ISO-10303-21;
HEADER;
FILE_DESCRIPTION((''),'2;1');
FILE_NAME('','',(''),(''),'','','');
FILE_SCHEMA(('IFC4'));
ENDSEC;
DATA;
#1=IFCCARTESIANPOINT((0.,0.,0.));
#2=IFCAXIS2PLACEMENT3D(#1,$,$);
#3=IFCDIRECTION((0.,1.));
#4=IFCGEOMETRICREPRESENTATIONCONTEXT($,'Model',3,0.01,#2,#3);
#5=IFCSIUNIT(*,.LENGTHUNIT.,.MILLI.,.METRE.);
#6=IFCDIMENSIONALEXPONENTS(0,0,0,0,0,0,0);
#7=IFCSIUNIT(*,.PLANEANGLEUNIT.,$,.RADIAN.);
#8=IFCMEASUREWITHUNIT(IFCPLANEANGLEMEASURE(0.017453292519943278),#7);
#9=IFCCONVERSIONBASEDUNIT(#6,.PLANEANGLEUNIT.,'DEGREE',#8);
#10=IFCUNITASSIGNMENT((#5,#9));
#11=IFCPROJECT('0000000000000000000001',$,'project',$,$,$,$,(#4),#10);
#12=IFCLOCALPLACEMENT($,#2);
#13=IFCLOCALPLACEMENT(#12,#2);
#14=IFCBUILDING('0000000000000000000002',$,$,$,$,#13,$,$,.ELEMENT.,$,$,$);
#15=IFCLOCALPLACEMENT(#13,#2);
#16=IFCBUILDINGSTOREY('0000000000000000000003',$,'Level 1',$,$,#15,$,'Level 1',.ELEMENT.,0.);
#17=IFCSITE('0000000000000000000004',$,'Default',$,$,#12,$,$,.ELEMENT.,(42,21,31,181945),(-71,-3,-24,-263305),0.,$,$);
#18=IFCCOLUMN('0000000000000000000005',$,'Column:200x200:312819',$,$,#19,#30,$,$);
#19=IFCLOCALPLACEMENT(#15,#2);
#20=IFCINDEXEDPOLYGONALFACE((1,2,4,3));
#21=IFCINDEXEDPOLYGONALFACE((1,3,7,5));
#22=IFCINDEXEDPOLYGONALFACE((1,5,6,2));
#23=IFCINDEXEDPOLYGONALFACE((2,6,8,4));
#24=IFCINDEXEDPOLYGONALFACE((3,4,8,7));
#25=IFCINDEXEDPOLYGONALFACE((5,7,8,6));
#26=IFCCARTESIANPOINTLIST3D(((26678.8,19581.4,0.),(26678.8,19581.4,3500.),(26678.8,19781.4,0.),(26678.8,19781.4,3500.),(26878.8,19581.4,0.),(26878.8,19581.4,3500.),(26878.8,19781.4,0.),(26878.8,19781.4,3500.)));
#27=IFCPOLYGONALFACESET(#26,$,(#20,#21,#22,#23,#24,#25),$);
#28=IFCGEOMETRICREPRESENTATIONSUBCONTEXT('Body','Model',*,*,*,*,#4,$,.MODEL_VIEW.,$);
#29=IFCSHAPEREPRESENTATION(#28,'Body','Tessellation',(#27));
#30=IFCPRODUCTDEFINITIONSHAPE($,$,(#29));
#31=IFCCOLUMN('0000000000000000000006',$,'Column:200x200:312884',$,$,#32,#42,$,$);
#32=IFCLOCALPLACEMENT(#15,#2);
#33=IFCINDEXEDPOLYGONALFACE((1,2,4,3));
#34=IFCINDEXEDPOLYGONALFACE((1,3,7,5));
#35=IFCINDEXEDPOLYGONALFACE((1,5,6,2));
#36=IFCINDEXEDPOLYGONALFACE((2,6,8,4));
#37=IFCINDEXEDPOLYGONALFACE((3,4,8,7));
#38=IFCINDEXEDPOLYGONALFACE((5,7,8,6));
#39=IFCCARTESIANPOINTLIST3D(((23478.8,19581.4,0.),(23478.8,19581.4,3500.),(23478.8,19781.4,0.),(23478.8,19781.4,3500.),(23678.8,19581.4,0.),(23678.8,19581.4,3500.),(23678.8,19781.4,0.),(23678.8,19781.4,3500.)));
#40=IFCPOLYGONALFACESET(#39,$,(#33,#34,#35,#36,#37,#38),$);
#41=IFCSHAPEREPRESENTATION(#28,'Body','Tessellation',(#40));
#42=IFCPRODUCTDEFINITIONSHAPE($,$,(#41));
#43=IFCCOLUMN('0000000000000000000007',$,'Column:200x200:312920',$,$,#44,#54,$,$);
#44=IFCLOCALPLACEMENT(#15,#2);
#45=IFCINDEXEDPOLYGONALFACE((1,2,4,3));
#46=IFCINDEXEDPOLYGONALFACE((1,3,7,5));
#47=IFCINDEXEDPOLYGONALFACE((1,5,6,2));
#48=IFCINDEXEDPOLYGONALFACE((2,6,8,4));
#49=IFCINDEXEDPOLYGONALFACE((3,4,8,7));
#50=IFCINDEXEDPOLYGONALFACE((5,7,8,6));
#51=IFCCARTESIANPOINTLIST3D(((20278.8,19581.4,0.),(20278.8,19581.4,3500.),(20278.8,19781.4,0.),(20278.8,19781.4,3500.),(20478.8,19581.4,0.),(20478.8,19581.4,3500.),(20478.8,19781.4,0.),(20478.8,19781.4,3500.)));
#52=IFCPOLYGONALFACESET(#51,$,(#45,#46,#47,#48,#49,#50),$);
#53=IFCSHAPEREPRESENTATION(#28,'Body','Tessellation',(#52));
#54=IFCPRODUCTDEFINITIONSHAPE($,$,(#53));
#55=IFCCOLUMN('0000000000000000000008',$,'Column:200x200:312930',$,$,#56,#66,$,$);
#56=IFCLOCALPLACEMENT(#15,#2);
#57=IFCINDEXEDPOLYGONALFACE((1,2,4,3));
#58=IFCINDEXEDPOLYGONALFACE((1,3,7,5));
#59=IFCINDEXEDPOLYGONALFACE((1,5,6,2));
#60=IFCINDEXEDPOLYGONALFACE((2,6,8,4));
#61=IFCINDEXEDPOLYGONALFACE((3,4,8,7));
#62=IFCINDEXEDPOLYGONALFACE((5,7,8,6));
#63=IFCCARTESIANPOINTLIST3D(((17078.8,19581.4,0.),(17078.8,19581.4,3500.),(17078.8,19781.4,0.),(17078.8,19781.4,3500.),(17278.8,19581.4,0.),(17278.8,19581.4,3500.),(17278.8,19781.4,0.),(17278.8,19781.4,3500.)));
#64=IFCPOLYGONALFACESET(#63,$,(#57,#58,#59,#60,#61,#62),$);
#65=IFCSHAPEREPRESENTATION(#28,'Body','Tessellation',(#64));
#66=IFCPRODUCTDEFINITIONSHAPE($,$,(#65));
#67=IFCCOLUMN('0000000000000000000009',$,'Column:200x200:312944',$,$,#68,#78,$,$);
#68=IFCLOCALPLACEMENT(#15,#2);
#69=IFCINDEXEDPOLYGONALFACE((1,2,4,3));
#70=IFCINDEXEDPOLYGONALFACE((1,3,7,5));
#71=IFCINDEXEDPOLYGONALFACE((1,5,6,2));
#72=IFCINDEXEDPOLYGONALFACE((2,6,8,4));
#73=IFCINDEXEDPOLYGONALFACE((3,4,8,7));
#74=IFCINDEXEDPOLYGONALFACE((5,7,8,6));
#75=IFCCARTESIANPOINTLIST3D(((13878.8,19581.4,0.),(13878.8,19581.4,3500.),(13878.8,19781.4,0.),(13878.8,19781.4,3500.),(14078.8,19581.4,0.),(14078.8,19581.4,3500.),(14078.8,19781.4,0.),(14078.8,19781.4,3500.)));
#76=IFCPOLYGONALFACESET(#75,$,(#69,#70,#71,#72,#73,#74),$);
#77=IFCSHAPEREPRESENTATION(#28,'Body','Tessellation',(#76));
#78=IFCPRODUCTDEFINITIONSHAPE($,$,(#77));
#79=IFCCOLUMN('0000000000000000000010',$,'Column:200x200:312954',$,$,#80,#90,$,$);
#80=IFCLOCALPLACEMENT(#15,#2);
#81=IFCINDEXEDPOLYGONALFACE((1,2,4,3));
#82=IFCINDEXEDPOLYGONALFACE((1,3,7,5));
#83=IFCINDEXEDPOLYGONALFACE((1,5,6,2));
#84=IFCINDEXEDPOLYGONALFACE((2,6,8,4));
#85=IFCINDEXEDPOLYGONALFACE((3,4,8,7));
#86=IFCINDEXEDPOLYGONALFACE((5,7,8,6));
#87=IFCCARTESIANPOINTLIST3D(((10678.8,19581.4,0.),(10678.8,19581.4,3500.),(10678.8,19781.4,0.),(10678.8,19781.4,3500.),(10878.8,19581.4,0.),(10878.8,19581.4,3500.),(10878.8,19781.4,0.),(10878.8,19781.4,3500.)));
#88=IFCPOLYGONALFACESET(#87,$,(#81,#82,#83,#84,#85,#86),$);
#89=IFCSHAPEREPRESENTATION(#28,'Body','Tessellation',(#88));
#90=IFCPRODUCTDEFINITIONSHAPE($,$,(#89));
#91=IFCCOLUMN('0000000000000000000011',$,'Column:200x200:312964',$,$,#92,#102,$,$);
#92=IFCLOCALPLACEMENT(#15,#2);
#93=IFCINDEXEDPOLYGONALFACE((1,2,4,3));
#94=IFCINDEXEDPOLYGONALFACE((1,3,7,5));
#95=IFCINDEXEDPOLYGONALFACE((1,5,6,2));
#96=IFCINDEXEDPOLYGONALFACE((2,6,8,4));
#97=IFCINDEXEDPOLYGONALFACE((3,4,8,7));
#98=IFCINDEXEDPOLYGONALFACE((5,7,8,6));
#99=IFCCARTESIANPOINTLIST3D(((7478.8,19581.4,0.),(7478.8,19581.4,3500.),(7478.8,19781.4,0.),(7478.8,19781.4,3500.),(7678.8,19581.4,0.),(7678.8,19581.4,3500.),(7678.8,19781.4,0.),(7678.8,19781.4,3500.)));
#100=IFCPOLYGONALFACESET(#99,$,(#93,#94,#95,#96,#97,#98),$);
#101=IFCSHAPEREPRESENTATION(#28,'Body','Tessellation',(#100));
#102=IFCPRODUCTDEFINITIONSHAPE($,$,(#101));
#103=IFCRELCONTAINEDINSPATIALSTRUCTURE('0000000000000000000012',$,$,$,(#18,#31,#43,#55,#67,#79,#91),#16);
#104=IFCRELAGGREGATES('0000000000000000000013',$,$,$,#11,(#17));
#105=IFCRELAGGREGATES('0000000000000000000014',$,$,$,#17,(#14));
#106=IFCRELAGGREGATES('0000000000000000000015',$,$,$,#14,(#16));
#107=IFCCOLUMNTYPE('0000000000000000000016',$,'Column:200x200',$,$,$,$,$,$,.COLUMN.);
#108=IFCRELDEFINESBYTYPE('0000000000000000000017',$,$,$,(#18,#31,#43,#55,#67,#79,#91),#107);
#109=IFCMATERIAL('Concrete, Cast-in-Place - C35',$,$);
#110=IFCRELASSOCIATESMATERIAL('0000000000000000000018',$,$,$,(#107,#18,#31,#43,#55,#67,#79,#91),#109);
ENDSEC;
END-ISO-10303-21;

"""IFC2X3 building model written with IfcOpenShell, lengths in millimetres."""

from ifc_helpers import new_model, entity, si_unit, converted_unit, direction, frame, frame_2d, origin, place, context, subcontext, project, spatial, rectangle, extrude, source, transform, mapped, material, type_object, type_shapes, element, save


model = new_model("IFC2X3")

# Units and contexts
model_context = context("Model", 3, precision=0.01, world=origin(), true_north=direction((0.0, 1.0)))
body_context = subcontext(model_context, "Body", "Model", "MODEL_VIEW")
ifc_project = project(units=[si_unit("LENGTHUNIT", "METRE", prefix="MILLI"), converted_unit("PLANEANGLEUNIT", "DEGREE", entity("IfcPlaneAngleMeasure", 0.017453292519943278), si_unit("PLANEANGLEUNIT", "RADIAN"), dimensions=[0, 0, 0, 0, 0, 0, 0])], contexts=[model_context])

# Site, building, storey
site_placement = place(None, origin())
site = spatial("IfcSite", under=ifc_project, at=site_placement, Name="Default", CompositionType="ELEMENT", RefLatitude=(42, 21, 31, 181945), RefLongitude=(-71, -3, -24, -263305), RefElevation=0.0)
building_placement = place(site_placement, origin())
building = spatial("IfcBuilding", under=site, at=building_placement, CompositionType="ELEMENT")
storey_placement = place(building_placement, origin())
storey = spatial("IfcBuildingStorey", under=building, at=storey_placement, Name="Level 1", LongName="Level 1", CompositionType="ELEMENT", Elevation=0.0)

# Columns
ifc_material = material(Name="Concrete, Cast-in-Place - C35")
column_type_1 = type_object("IfcColumnType", Name="Column:200x200", PredefinedType="COLUMN", material=ifc_material)
shared_shape_1 = source(origin(), body_context, "Body", "SweptSolid", [
    extrude(rectangle(XDim=200.0, YDim=200.0, at=frame_2d((0.0, 0.0), x_axis=(1.0, 0.0))), frame((0.0, 0.0, 0.0), z_axis=(0.0, 0.0, 1.0), x_axis=(-1.0, 0.0, 0.0)), (0.0, 0.0, 1.0), 3500.0),
])
type_shapes(column_type_1, [shared_shape_1])
for number, where, name in (
    (1, (26778.8, 19681.4, 0.0), "Column:200x200:312819"),
    (2, (23578.8, 19681.4, 0.0), "Column:200x200:312884"),
    (3, (20378.8, 19681.4, 0.0), "Column:200x200:312920"),
    (4, (17178.8, 19681.4, 0.0), "Column:200x200:312930"),
    (5, (13978.8, 19681.4, 0.0), "Column:200x200:312944"),
    (6, (10778.8, 19681.4, 0.0), "Column:200x200:312954"),
    (7, (7578.8, 19681.4, 0.0), "Column:200x200:312964"),
):
    element("IfcColumn", number, at=place(storey_placement, frame(where)), inside=storey, type_object=column_type_1, material=ifc_material, Name=name, context=body_context, shape_type="MappedRepresentation", body=[
        mapped(shared_shape_1, transform((0.0, 0.0, 0.0), scale=1.0)),
    ])

save(model, "model.ifc")
